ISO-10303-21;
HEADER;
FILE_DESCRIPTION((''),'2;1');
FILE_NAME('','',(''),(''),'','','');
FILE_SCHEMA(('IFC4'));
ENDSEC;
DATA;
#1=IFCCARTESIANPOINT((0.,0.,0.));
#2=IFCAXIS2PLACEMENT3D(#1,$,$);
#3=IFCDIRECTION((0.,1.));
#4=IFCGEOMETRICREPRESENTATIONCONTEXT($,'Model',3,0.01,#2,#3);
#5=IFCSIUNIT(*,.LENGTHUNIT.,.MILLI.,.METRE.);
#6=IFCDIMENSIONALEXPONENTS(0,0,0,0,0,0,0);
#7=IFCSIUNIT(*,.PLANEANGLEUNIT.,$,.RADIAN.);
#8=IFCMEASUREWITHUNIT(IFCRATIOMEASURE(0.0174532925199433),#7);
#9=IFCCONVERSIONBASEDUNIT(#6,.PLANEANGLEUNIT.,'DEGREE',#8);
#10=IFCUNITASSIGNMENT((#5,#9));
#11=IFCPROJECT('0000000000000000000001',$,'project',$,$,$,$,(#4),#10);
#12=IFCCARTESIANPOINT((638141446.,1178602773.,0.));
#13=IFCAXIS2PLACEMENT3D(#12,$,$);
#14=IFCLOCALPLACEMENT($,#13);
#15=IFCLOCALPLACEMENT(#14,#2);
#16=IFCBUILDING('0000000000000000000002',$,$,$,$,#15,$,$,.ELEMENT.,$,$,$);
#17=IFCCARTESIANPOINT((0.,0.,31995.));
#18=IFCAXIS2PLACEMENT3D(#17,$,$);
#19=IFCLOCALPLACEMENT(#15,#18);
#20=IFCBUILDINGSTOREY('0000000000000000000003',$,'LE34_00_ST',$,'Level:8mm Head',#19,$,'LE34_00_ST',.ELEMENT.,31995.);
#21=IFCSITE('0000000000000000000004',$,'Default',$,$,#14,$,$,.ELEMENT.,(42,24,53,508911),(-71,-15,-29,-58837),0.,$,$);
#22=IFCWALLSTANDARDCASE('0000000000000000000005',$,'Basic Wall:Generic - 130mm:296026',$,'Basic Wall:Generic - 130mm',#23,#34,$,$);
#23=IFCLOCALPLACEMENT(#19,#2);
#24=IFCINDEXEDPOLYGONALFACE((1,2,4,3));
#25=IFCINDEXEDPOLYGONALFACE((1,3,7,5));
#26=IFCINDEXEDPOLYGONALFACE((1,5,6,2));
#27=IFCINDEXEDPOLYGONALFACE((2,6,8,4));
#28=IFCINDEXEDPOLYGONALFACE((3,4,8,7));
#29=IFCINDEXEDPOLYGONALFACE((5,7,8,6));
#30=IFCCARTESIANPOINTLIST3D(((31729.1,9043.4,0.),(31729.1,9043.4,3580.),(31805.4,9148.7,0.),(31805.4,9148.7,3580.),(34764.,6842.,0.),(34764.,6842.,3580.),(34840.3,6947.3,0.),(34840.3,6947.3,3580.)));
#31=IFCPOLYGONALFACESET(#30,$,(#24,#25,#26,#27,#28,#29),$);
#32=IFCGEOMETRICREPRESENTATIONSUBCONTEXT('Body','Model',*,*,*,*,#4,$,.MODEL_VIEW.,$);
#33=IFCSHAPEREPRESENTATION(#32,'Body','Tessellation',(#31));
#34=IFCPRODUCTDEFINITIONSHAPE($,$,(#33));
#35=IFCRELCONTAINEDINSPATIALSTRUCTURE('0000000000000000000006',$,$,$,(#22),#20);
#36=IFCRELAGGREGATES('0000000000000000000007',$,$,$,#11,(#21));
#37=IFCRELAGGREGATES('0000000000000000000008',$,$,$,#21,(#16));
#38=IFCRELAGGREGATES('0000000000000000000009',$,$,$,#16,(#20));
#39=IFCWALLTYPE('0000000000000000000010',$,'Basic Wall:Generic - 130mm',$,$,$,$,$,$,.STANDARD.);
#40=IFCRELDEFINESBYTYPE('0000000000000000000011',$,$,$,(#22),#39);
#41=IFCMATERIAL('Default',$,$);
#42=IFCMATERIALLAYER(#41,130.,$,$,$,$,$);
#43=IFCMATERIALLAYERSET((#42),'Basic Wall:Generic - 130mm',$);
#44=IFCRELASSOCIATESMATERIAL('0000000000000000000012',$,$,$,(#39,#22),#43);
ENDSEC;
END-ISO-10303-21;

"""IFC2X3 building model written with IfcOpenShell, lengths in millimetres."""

from ifc_helpers import new_model, entity, si_unit, converted_unit, direction, frame, origin, place, context, subcontext, project, spatial, polyline, outline, extrude, material, layer, layer_set, layer_usage, type_object, element, save


model = new_model("IFC2X3")

# Units and contexts
model_context = context("Model", 3, precision=0.01, world=origin(), true_north=direction((0.0, 1.0)))
body_context = subcontext(model_context, "Body", "Model", "MODEL_VIEW")
ifc_project = project(units=[si_unit("LENGTHUNIT", "METRE", prefix="MILLI"), converted_unit("PLANEANGLEUNIT", "DEGREE", entity("IfcRatioMeasure", 0.0174532925199433), si_unit("PLANEANGLEUNIT", "RADIAN"), dimensions=[0, 0, 0, 0, 0, 0, 0])], contexts=[model_context])

# Site, building, storey
site_placement = place(None, frame((638141446.0, 1178602773.0, 0.0)))
site = spatial("IfcSite", under=ifc_project, at=site_placement, Name="Default", CompositionType="ELEMENT", RefLatitude=(42, 24, 53, 508911), RefLongitude=(-71, -15, -29, -58837), RefElevation=0.0)
building_placement = place(site_placement, origin())
building = spatial("IfcBuilding", under=site, at=building_placement, CompositionType="ELEMENT")
storey_placement = place(building_placement, frame((0.0, 0.0, 31995.0)))
storey = spatial("IfcBuildingStorey", under=building, at=storey_placement, Name="LE34_00_ST", ObjectType="Level:8mm Head", LongName="LE34_00_ST", CompositionType="ELEMENT", Elevation=31995.0)

# Wall
ifc_material = material(Name="Default")
ifc_layer_1 = layer(ifc_material, 130.0)
ifc_layer_set_1 = layer_set([ifc_layer_1], Name="Basic Wall:Generic - 130mm")
ifc_layer_usage_1 = layer_usage(ifc_layer_set_1, "AXIS2", "NEGATIVE", 65.0)
wall_type_1 = type_object("IfcWallType", Name="Basic Wall:Generic - 130mm", PredefinedType="STANDARD", material=ifc_layer_set_1)
wall_1_placement = place(storey_placement, frame((31767.2, 9096.1, 0.0), z_axis=(0.0, 0.0, 1.0), x_axis=(0.809468, -0.587164, 0.0)))
element("IfcWallStandardCase", 1, at=wall_1_placement, inside=storey, type_object=wall_type_1, material=ifc_layer_usage_1, Name="Basic Wall:Generic - 130mm:296026", ObjectType="Basic Wall:Generic - 130mm", context=body_context, shape_type="SweptSolid", body=[
    extrude(outline(polyline([(3749.3, -65.0), (3749.3, 65.0), (0.0, 65.0), (0.1, -65.0), (3749.3, -65.0)])), origin(), (0.0, 0.0, 1.0), 3580.0),
])

save(model, "model.ifc")
